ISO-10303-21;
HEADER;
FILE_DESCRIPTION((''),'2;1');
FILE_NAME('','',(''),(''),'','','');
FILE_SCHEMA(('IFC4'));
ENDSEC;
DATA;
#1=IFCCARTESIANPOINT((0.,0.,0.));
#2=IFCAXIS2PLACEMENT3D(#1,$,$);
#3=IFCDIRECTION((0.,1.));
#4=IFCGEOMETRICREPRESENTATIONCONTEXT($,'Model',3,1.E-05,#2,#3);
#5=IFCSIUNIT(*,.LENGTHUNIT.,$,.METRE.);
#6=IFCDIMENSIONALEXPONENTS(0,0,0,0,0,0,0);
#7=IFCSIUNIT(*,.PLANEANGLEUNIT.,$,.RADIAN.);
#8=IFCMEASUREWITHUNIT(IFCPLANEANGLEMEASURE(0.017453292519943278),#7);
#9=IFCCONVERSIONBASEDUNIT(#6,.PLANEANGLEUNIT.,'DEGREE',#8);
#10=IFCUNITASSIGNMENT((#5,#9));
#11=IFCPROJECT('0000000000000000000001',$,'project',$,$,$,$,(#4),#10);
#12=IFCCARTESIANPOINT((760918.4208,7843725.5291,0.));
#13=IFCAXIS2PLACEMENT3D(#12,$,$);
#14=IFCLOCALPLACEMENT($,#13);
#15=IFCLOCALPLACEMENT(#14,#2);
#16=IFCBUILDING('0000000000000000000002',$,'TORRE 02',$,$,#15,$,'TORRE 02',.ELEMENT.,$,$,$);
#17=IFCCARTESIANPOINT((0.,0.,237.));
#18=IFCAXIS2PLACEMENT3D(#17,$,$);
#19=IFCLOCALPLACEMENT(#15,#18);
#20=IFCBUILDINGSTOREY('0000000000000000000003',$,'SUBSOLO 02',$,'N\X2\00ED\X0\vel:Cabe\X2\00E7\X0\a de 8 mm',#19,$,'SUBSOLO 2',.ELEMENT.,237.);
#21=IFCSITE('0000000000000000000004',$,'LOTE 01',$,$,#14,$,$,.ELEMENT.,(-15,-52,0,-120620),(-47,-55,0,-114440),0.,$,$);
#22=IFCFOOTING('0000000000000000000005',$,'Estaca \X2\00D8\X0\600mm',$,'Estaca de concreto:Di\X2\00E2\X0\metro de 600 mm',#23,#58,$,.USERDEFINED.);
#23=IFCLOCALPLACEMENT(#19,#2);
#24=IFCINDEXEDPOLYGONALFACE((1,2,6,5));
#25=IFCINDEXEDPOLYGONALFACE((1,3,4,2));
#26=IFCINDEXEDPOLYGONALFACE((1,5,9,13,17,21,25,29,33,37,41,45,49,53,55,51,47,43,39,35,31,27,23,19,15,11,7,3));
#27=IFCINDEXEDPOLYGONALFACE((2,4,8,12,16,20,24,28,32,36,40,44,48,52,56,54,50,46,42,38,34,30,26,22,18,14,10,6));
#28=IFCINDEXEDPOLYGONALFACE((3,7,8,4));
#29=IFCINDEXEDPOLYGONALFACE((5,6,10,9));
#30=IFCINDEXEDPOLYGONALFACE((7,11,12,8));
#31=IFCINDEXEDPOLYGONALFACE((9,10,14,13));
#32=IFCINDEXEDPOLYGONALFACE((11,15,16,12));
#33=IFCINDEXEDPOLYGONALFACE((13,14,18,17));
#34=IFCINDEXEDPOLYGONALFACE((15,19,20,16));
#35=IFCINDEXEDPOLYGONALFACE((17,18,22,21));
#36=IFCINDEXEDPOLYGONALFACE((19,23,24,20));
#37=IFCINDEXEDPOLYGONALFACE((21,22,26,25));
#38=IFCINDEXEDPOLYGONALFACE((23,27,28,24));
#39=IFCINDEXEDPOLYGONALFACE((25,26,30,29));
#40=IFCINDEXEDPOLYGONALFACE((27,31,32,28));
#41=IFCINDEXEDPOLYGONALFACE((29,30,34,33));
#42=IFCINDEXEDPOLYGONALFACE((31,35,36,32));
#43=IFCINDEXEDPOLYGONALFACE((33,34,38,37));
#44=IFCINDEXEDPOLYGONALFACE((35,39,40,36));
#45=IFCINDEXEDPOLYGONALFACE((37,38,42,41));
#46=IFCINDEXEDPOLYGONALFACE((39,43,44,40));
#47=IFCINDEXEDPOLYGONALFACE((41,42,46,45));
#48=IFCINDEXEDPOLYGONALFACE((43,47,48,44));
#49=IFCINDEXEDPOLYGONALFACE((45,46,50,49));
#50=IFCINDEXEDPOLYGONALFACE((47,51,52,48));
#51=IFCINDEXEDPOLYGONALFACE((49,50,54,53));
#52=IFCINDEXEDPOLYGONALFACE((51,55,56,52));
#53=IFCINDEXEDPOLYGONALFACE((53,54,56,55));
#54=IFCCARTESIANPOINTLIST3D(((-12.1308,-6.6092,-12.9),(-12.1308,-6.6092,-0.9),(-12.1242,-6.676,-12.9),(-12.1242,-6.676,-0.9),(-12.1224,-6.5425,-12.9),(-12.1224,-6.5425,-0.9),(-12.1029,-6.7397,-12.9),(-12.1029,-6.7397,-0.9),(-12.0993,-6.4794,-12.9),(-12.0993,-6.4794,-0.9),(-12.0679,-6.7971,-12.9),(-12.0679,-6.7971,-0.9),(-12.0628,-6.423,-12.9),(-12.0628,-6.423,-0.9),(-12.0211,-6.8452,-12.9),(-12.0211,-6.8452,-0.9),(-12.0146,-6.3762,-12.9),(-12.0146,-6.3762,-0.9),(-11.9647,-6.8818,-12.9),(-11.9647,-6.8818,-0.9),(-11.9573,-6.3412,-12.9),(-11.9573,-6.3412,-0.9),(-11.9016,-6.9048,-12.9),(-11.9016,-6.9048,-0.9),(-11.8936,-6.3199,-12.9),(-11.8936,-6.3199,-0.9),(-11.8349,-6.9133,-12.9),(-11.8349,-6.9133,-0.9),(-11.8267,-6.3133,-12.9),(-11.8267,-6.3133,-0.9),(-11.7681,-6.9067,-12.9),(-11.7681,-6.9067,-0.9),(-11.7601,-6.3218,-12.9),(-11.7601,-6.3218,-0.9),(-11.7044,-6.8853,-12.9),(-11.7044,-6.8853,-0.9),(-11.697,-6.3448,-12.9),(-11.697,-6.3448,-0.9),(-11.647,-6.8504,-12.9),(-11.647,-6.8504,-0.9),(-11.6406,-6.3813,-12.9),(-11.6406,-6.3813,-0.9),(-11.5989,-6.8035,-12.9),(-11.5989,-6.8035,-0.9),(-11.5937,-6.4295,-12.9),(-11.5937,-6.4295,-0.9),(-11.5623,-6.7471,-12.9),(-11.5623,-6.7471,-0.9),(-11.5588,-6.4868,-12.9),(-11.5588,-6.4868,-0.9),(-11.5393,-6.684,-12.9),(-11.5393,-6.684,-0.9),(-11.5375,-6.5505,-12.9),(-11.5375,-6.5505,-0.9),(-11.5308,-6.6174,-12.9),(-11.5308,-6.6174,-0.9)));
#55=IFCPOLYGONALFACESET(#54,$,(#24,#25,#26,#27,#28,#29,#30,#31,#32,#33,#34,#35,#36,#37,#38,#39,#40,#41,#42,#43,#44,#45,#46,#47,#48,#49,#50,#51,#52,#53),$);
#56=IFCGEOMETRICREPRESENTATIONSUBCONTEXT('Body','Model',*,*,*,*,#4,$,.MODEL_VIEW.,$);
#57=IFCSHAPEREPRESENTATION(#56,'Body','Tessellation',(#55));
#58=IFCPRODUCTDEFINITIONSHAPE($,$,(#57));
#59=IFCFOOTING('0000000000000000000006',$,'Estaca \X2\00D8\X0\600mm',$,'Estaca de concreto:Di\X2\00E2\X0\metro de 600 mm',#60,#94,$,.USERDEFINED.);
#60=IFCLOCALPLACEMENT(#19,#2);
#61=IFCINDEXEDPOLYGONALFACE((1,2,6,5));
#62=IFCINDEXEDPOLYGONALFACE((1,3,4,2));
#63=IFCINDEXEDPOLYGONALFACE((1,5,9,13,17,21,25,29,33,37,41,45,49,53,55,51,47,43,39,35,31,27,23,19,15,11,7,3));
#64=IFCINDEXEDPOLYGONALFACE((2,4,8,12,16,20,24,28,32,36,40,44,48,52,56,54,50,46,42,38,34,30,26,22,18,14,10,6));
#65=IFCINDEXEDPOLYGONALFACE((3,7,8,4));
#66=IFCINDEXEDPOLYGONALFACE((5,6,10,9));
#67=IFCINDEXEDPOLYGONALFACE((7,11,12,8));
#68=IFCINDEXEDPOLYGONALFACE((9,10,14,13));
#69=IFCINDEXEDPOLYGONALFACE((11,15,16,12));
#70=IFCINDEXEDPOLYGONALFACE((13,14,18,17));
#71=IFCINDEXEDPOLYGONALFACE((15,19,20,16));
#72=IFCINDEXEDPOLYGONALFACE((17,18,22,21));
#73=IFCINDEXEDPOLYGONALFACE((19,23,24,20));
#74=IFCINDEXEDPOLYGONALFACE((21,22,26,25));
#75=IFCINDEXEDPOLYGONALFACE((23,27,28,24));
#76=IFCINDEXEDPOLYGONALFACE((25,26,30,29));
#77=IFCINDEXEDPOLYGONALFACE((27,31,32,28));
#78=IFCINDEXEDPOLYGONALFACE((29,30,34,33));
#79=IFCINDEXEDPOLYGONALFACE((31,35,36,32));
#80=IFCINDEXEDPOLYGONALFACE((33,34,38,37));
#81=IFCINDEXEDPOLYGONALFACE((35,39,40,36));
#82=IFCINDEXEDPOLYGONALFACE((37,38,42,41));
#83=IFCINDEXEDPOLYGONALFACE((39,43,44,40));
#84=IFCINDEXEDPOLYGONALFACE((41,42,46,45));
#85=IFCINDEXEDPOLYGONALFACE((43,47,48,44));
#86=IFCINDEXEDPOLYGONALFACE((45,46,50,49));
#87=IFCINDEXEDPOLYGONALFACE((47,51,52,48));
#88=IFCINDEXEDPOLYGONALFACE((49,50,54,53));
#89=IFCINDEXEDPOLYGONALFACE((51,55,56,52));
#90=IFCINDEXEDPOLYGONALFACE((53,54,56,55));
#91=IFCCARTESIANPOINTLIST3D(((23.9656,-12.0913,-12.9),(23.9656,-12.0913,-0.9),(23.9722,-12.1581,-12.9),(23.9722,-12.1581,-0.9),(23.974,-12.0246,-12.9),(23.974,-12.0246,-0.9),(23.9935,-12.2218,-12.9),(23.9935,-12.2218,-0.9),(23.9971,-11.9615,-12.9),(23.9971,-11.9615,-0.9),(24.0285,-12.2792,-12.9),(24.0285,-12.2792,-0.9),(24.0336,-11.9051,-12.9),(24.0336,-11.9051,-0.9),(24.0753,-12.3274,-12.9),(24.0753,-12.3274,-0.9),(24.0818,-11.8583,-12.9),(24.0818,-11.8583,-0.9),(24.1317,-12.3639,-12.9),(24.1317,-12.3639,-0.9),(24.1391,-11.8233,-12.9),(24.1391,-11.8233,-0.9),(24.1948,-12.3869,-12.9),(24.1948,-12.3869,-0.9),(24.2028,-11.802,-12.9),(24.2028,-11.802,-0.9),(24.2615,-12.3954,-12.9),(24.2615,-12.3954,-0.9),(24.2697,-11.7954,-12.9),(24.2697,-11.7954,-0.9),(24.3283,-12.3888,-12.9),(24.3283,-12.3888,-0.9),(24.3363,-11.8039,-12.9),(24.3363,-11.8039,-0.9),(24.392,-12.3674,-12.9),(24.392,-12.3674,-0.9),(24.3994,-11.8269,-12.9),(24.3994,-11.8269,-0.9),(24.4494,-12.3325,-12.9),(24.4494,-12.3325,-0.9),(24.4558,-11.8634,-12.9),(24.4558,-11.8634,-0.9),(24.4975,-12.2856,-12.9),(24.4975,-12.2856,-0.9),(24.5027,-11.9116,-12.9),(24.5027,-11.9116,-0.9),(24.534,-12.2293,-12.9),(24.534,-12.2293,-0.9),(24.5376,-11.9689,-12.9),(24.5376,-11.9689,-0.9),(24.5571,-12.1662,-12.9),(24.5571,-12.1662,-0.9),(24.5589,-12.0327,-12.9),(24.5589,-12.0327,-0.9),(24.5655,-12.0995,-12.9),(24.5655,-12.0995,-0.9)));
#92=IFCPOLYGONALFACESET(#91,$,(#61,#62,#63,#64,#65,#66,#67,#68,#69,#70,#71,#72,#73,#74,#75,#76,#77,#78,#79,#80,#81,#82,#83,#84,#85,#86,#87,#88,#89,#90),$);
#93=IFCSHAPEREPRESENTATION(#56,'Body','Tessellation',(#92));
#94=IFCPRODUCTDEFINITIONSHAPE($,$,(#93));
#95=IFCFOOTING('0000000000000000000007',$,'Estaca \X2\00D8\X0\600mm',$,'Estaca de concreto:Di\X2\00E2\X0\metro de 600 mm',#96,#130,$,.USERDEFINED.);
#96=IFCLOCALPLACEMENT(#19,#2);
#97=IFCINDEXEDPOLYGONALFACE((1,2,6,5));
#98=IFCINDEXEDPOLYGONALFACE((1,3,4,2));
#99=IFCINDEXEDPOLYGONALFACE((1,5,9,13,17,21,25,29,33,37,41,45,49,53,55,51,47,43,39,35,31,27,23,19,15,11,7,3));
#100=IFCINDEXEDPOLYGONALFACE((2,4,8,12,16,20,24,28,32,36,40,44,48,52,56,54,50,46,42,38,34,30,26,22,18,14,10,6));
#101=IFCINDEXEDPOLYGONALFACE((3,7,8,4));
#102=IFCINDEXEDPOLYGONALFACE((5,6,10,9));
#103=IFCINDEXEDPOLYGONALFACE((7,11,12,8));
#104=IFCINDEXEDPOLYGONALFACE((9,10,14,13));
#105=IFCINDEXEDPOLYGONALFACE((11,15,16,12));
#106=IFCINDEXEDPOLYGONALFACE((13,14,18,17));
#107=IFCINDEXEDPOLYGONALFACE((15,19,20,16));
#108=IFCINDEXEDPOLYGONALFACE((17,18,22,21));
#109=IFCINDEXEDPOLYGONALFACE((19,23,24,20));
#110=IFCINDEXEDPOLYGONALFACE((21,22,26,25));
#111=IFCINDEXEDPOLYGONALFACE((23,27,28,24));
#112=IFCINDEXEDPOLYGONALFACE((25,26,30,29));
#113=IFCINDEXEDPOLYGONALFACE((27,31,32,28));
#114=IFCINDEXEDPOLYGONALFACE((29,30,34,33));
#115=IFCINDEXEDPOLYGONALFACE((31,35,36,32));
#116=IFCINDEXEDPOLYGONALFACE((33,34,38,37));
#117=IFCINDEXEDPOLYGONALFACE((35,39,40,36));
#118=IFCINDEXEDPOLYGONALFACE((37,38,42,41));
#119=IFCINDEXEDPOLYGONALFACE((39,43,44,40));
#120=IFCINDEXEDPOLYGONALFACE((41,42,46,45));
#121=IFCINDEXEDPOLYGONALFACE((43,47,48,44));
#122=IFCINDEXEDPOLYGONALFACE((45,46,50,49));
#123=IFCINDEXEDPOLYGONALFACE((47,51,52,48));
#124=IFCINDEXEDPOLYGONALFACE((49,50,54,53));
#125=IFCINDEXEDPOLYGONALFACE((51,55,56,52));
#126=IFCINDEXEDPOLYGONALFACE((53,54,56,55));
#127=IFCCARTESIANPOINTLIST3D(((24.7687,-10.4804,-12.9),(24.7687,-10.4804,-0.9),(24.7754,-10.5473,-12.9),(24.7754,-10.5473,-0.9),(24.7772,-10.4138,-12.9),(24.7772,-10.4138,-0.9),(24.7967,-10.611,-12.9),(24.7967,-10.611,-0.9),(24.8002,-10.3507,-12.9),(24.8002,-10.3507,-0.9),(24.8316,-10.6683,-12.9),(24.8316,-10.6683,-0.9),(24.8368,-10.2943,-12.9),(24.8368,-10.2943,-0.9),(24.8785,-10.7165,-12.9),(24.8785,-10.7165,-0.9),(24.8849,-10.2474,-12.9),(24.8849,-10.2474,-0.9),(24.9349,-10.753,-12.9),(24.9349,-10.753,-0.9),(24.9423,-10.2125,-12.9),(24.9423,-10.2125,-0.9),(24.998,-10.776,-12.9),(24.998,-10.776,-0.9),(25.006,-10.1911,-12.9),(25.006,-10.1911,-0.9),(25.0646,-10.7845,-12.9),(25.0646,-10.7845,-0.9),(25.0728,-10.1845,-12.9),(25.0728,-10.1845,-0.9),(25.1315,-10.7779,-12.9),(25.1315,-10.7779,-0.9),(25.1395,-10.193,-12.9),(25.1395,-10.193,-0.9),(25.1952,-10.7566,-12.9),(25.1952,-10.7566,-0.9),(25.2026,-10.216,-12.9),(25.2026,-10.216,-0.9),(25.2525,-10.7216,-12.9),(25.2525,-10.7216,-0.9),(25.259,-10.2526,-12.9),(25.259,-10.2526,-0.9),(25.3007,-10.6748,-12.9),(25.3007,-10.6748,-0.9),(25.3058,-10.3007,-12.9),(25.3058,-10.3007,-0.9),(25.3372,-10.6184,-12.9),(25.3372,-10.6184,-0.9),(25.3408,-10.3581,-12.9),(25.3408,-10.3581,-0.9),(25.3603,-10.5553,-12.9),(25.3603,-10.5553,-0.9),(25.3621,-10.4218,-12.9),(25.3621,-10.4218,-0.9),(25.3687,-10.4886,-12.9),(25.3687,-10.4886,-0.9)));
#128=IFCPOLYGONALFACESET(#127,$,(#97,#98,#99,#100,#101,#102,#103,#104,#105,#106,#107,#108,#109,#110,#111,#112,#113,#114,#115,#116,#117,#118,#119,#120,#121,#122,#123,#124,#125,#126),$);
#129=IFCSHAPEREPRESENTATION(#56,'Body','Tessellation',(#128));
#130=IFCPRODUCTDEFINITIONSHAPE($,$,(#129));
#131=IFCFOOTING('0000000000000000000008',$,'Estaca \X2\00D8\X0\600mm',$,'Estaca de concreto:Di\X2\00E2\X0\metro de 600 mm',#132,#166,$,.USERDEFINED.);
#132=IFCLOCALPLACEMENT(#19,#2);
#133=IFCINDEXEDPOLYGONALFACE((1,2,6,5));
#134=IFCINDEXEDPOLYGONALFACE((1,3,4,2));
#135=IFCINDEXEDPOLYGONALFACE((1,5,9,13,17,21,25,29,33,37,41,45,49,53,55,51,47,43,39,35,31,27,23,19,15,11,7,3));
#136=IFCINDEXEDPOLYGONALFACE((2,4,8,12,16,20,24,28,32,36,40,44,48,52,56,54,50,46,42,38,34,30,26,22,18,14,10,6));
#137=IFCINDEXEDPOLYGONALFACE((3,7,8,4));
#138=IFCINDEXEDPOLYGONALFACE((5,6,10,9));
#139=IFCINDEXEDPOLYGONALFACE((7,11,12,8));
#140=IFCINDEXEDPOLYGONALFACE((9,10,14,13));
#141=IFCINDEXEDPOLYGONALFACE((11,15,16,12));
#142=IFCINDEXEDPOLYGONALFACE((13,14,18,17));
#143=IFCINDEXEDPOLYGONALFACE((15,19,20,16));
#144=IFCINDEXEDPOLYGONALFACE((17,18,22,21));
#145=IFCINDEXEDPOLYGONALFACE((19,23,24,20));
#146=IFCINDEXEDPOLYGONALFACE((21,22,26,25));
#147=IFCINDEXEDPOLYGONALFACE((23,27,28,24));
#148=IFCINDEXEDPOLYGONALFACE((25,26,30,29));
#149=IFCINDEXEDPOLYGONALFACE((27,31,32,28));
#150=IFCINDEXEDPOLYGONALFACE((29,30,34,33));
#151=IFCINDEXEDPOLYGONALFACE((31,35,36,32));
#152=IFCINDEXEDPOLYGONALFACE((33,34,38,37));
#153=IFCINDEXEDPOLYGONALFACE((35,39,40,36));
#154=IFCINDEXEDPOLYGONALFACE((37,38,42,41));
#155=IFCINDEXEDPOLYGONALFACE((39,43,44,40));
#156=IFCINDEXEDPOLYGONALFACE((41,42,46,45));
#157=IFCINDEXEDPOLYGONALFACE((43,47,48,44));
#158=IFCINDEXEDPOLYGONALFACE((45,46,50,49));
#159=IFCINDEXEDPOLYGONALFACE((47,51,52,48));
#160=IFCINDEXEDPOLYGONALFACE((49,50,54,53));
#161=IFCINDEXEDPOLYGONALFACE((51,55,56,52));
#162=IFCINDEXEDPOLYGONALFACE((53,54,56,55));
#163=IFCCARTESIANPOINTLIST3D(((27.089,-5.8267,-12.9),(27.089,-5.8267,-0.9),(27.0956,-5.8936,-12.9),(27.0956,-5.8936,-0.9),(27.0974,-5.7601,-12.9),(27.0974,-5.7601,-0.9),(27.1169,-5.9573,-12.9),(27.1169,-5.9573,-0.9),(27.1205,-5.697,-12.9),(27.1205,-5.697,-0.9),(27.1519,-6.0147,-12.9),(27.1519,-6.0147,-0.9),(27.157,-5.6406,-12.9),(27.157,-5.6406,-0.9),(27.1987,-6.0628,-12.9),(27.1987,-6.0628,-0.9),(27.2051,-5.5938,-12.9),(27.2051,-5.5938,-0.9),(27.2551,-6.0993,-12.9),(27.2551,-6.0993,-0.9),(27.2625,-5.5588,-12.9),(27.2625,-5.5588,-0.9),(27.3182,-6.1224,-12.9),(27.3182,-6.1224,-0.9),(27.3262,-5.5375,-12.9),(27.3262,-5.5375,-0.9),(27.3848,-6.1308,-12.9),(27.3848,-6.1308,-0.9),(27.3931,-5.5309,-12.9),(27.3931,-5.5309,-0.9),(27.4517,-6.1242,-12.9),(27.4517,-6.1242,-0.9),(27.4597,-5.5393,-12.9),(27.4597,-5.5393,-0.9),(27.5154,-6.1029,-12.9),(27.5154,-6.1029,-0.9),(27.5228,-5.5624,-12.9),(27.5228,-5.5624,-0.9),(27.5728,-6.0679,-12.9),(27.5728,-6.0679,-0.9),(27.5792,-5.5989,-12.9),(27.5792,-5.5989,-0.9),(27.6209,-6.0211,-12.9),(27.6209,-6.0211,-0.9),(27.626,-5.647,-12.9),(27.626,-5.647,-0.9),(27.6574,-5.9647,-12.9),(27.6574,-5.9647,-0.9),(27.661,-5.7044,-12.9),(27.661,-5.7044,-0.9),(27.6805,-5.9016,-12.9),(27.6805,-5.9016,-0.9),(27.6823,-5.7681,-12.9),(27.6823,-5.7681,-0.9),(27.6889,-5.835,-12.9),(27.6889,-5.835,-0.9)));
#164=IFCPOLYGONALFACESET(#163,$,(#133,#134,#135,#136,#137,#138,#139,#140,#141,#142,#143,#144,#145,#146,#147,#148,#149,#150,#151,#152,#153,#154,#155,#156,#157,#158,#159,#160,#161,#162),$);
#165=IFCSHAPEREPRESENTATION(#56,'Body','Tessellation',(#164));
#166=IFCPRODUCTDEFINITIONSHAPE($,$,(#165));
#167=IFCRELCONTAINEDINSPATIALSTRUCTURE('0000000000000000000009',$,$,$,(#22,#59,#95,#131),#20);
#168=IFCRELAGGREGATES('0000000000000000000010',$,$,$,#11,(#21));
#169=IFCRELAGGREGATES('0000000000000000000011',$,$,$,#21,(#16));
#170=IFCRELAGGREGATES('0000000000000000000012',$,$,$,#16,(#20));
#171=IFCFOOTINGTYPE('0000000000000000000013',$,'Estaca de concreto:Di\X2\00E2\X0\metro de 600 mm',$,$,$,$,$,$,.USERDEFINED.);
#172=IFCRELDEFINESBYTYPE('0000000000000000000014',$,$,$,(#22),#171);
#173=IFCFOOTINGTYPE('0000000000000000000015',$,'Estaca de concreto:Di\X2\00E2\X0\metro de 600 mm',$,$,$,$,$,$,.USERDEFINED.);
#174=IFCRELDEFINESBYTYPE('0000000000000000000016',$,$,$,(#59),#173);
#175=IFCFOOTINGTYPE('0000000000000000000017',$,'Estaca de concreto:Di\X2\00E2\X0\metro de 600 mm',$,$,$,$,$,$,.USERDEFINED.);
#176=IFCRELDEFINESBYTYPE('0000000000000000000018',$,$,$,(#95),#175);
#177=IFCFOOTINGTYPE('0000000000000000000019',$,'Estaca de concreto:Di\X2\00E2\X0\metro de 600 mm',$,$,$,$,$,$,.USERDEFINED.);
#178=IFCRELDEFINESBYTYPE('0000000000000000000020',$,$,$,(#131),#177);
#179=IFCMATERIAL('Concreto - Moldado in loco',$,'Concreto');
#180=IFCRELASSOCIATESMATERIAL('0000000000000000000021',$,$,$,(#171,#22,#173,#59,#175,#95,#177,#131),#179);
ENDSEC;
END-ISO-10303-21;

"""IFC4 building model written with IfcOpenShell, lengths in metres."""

from ifc_helpers import new_model, entity, si_unit, converted_unit, direction, frame, origin, place, context, subcontext, project, spatial, arc, indexed_curve, outline, extrude, source, transform, mapped, material, type_object, type_shapes, element, save


model = new_model("IFC4")

# Units and contexts
model_context = context("Model", 3, precision=1e-05, world=origin(), true_north=direction((0.0, 1.0)))
body_context = subcontext(model_context, "Body", "Model", "MODEL_VIEW")
ifc_project = project(units=[si_unit("LENGTHUNIT", "METRE"), converted_unit("PLANEANGLEUNIT", "DEGREE", entity("IfcPlaneAngleMeasure", 0.017453292519943278), si_unit("PLANEANGLEUNIT", "RADIAN"), dimensions=[0, 0, 0, 0, 0, 0, 0])], contexts=[model_context])

# Site, building, storey
site_placement = place(None, frame((760918.4208, 7843725.5291, 0.0)))
site = spatial("IfcSite", under=ifc_project, at=site_placement, Name="LOTE 01", CompositionType="ELEMENT", RefLatitude=(-15, -52, 0, -120620), RefLongitude=(-47, -55, 0, -114440), RefElevation=0.0)
building_placement = place(site_placement, origin())
building = spatial("IfcBuilding", under=site, at=building_placement, Name="TORRE 02", LongName="TORRE 02", CompositionType="ELEMENT")
storey_placement = place(building_placement, frame((0.0, 0.0, 237.0)))
storey = spatial("IfcBuildingStorey", under=building, at=storey_placement, Name="SUBSOLO 02", ObjectType="Nível:Cabeça de 8 mm", LongName="SUBSOLO 2", CompositionType="ELEMENT", Elevation=237.0)

# Footings
ifc_material_1 = material(Name="Concreto - Moldado in loco", Category="Concreto")
placement = place(building_placement, frame((0.0, 0.0, 237.0)))
footing_type_1 = type_object("IfcFootingType", Name="Estaca de concreto:Diâmetro de 600 mm", PredefinedType="USERDEFINED", material=ifc_material_1)
shared_shape_1 = source(origin(), body_context, "Body", "SweptSolid", [
    extrude(outline(indexed_curve([(-0.3, 0.0), (0.0, -0.3), (0.3, 0.0), (0.0, 0.3)], segments=[arc(1, 2, 3), arc(3, 4, 1)], self_intersect=False)), frame((-11.8308, -6.6133, -12.0), z_axis=(0.0, 0.0, 1.0), x_axis=(0.446198, 0.894934, 0.0)), (0.0, 0.0, 1.0), 12.0),
])
type_shapes(footing_type_1, [shared_shape_1])
footing_1_placement = place(placement, frame((0.0, 0.0, -0.9)))
element("IfcFooting", 1, at=footing_1_placement, inside=storey, type_object=footing_type_1, material=ifc_material_1, Name="Estaca Ø600mm", ObjectType="Estaca de concreto:Diâmetro de 600 mm", PredefinedType="USERDEFINED", context=body_context, shape_type="MappedRepresentation", body=[
    mapped(shared_shape_1, transform((0.0, 0.0, 0.0), scale=1.0)),
])
footing_type_2 = type_object("IfcFootingType", Name="Estaca de concreto:Diâmetro de 600 mm", PredefinedType="USERDEFINED", material=ifc_material_1)
shared_shape_2 = source(origin(), body_context, "Body", "SweptSolid", [
    extrude(outline(indexed_curve([(-0.3, 0.0), (0.0, -0.3), (0.3, 0.0), (0.0, 0.3)], segments=[arc(1, 2, 3), arc(3, 4, 1)], self_intersect=False)), frame((24.2656, -12.0954, -12.0), z_axis=(0.0, 0.0, 1.0), x_axis=(0.446198, 0.894934, 0.0)), (0.0, 0.0, 1.0), 12.0),
])
type_shapes(footing_type_2, [shared_shape_2])
footing_2_placement = place(placement, frame((0.0, 0.0, -0.9)))
element("IfcFooting", 2, at=footing_2_placement, inside=storey, type_object=footing_type_2, material=ifc_material_1, Name="Estaca Ø600mm", ObjectType="Estaca de concreto:Diâmetro de 600 mm", PredefinedType="USERDEFINED", context=body_context, shape_type="MappedRepresentation", body=[
    mapped(shared_shape_2, transform((0.0, 0.0, 0.0), scale=1.0)),
])
footing_type_3 = type_object("IfcFootingType", Name="Estaca de concreto:Diâmetro de 600 mm", PredefinedType="USERDEFINED", material=ifc_material_1)
shared_shape_3 = source(origin(), body_context, "Body", "SweptSolid", [
    extrude(outline(indexed_curve([(-0.3, 0.0), (0.0, -0.3), (0.3, 0.0), (0.0, 0.3)], segments=[arc(1, 2, 3), arc(3, 4, 1)], self_intersect=False)), frame((25.0687, -10.4845, -12.0), z_axis=(0.0, 0.0, 1.0), x_axis=(0.446198, 0.894934, 0.0)), (0.0, 0.0, 1.0), 12.0),
])
type_shapes(footing_type_3, [shared_shape_3])
footing_3_placement = place(placement, frame((0.0, 0.0, -0.9)))
element("IfcFooting", 3, at=footing_3_placement, inside=storey, type_object=footing_type_3, material=ifc_material_1, Name="Estaca Ø600mm", ObjectType="Estaca de concreto:Diâmetro de 600 mm", PredefinedType="USERDEFINED", context=body_context, shape_type="MappedRepresentation", body=[
    mapped(shared_shape_3, transform((0.0, 0.0, 0.0), scale=1.0)),
])
footing_type_4 = type_object("IfcFootingType", Name="Estaca de concreto:Diâmetro de 600 mm", PredefinedType="USERDEFINED", material=ifc_material_1)
shared_shape_4 = source(origin(), body_context, "Body", "SweptSolid", [
    extrude(outline(indexed_curve([(-0.3, 0.0), (0.0, -0.3), (0.3, 0.0), (0.0, 0.3)], segments=[arc(1, 2, 3), arc(3, 4, 1)], self_intersect=False)), frame((27.3889, -5.8309, -12.0), z_axis=(0.0, 0.0, 1.0), x_axis=(0.446198, 0.894934, 0.0)), (0.0, 0.0, 1.0), 12.0),
])
type_shapes(footing_type_4, [shared_shape_4])
footing_4_placement = place(placement, frame((0.0, 0.0, -0.9)))
element("IfcFooting", 4, at=footing_4_placement, inside=storey, type_object=footing_type_4, material=ifc_material_1, Name="Estaca Ø600mm", ObjectType="Estaca de concreto:Diâmetro de 600 mm", PredefinedType="USERDEFINED", context=body_context, shape_type="MappedRepresentation", body=[
    mapped(shared_shape_4, transform((0.0, 0.0, 0.0), scale=1.0)),
])

save(model, "model.ifc")
